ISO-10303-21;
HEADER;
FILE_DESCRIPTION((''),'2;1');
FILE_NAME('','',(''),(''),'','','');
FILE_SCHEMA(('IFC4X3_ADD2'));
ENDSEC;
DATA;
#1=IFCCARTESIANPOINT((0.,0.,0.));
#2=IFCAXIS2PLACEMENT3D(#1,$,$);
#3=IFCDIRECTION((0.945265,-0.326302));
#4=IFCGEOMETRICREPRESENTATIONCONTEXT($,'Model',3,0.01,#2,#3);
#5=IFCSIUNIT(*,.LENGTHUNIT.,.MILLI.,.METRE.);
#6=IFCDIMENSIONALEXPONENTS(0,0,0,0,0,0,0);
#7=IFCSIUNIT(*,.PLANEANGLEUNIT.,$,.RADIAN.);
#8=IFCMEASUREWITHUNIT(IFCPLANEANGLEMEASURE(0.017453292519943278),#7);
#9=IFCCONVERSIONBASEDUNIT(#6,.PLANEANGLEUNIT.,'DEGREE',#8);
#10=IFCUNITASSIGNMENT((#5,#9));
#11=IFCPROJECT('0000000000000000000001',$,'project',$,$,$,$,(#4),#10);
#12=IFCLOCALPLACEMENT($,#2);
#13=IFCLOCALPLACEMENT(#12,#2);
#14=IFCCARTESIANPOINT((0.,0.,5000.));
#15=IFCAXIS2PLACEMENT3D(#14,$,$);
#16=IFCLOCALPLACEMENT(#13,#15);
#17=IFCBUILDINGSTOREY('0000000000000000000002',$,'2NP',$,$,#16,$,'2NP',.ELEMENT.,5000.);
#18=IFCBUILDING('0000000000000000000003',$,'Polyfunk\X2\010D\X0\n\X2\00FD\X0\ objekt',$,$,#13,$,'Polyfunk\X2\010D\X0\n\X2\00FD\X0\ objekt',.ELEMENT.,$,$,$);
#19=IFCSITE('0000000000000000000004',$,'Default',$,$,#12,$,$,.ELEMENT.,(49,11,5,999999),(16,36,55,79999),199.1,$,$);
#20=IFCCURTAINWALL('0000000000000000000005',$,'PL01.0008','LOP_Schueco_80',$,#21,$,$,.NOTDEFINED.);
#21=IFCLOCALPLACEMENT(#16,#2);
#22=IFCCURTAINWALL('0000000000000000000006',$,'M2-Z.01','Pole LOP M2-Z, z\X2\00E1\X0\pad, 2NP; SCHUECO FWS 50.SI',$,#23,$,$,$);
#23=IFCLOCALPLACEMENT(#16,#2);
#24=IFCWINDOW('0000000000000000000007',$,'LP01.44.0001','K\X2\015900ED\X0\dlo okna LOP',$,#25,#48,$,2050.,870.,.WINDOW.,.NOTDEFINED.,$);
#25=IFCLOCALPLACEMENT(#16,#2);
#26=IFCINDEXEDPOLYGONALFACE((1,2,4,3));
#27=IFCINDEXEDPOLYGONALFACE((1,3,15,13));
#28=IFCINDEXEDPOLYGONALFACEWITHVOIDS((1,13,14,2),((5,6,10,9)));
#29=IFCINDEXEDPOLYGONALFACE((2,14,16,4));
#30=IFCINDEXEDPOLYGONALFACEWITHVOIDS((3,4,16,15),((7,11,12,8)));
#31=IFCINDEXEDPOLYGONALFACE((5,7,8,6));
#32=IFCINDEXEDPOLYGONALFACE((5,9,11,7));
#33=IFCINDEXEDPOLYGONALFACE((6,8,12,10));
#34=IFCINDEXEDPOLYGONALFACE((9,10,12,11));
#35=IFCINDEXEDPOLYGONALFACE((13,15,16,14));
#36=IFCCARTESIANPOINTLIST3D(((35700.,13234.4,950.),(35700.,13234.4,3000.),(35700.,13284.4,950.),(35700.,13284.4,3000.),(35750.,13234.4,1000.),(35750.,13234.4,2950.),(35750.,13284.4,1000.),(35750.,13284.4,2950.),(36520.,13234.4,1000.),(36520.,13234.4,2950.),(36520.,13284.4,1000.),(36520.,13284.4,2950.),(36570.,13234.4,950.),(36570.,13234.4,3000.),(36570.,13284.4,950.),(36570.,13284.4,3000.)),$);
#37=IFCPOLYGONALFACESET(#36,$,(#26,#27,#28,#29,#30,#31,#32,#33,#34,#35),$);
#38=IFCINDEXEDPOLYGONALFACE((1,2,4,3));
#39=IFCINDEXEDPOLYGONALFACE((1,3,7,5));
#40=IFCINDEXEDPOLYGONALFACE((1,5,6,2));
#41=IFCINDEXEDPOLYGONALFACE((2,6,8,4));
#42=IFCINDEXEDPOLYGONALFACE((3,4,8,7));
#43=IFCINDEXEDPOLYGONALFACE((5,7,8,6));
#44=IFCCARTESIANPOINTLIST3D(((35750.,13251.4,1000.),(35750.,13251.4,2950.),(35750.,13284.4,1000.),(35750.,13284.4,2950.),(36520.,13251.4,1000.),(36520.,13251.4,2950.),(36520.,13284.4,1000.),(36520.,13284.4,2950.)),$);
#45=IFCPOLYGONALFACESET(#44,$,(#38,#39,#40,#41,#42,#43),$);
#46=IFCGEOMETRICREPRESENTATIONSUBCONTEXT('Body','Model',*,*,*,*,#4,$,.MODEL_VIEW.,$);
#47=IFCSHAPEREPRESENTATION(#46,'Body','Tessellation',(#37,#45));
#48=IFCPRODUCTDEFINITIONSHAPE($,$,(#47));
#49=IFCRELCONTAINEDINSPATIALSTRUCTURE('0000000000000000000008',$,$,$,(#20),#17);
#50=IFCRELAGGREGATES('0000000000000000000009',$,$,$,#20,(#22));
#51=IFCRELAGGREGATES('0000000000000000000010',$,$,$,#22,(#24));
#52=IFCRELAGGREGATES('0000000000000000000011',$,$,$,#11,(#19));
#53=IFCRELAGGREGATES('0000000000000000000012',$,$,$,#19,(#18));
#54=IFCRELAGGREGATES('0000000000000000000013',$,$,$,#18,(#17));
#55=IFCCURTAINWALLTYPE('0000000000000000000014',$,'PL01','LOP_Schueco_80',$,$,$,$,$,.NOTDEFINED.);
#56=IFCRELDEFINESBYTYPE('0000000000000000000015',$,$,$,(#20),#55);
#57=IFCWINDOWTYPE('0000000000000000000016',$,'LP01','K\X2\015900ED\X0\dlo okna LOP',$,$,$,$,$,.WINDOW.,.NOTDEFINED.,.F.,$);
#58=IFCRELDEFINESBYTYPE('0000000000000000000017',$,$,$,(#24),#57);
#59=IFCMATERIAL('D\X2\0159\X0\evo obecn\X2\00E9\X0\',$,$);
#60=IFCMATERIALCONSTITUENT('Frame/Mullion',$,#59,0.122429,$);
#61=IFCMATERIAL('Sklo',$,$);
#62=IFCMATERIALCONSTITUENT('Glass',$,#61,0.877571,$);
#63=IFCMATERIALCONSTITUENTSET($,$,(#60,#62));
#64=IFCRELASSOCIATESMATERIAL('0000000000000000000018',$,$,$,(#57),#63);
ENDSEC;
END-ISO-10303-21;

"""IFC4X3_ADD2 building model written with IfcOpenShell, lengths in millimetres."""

from ifc_helpers import new_model, entity, si_unit, converted_unit, direction, frame, origin, origin_2d_with_axis, place, context, subcontext, project, spatial, polyline, rectangle, outline, extrude, source, transform, mapped, material, constituent, constituent_set, type_object, type_shapes, element, aggregate, save


model = new_model("IFC4X3_ADD2")

# Units and contexts
model_context = context("Model", 3, precision=0.01, world=origin(), true_north=direction((0.945265, -0.326302)))
body_context = subcontext(model_context, "Body", "Model", "MODEL_VIEW")
ifc_project = project(units=[si_unit("LENGTHUNIT", "METRE", prefix="MILLI"), converted_unit("PLANEANGLEUNIT", "DEGREE", entity("IfcPlaneAngleMeasure", 0.017453292519943278), si_unit("PLANEANGLEUNIT", "RADIAN"), dimensions=[0, 0, 0, 0, 0, 0, 0])], contexts=[model_context])

# Site, building, storey
site_placement = place(None, origin())
site = spatial("IfcSite", under=ifc_project, at=site_placement, Name="Default", CompositionType="ELEMENT", RefLatitude=(49, 11, 5, 999999), RefLongitude=(16, 36, 55, 79999), RefElevation=199.1)
building_placement = place(site_placement, origin())
building = spatial("IfcBuilding", under=site, at=building_placement, Name="Polyfunkčný objekt", LongName="Polyfunkčný objekt", CompositionType="ELEMENT")
storey_placement = place(building_placement, frame((0.0, 0.0, 5000.0)))
storey = spatial("IfcBuildingStorey", under=building, at=storey_placement, Name="2NP", LongName="2NP", CompositionType="ELEMENT", Elevation=5000.0)

# Curtain walls
curtain_wall_type = type_object("IfcCurtainWallType", Name="PL01", Description="LOP_Schueco_80", PredefinedType="NOTDEFINED")
curtain_wall_1_placement = place(storey_placement, frame((0.0, 0.0, -5000.0)))
curtain_wall_1 = element("IfcCurtainWall", 1, at=curtain_wall_1_placement, inside=storey, type_object=curtain_wall_type, Name="PL01.0008", Description="LOP_Schueco_80", PredefinedType="NOTDEFINED")
curtain_wall_2 = element("IfcCurtainWall", 2, Name="M2-Z.01", Description="Pole LOP M2-Z, západ, 2NP; SCHUECO FWS 50.SI")
aggregate(curtain_wall_1, [curtain_wall_2])
ifc_material_1 = material(Name="Sklo")

# Window
ifc_material_2 = material(Name="Dřevo obecné")
ifc_constituent_1 = constituent(ifc_material_2, Name="Frame/Mullion", fraction=0.122429)
ifc_constituent_2 = constituent(ifc_material_1, Name="Glass", fraction=0.877571)
ifc_constituent_set = constituent_set(constituents=[ifc_constituent_1, ifc_constituent_2])
window_type = type_object("IfcWindowType", Name="LP01", Description="Křídlo okna LOP", ParameterTakesPrecedence=False, PartitioningType="NOTDEFINED", PredefinedType="WINDOW", material=ifc_constituent_set)
shared_shape_1 = source(origin(), body_context, "Body", "SweptSolid", [
    extrude(outline(polyline([(-1025.0, -435.0), (1025.0, -435.0), (1025.0, 435.0), (-1025.0, 435.0), (-1025.0, -435.0)]), holes=[polyline([(-975.0, -385.0), (-975.0, 385.0), (975.0, 385.0), (975.0, -385.0), (-975.0, -385.0)])]), frame((0.0, 0.0, 1025.0), z_axis=(0.0, 1.0, 0.0), x_axis=(0.0, 0.0, -1.0)), (0.0, 0.0, 1.0), 50.0),
    extrude(rectangle(XDim=33.0, YDim=770.0, at=origin_2d_with_axis()), frame((0.0, 33.5, 50.0), z_axis=(0.0, 0.0, 1.0), x_axis=(0.0, -1.0, 0.0)), (0.0, 0.0, 1.0), 1950.0),
])
type_shapes(window_type, [shared_shape_1])
window_placement = place(curtain_wall_1_placement, frame((36135.0, 13234.4, 5950.0)))
window = element("IfcWindow", 3, at=window_placement, type_object=window_type, Name="LP01.44.0001", Description="Křídlo okna LOP", OverallHeight=2050.0, OverallWidth=870.0, PartitioningType="NOTDEFINED", PredefinedType="WINDOW", context=body_context, shape_type="MappedRepresentation", body=[
    mapped(shared_shape_1, transform((0.0, 0.0, 0.0), scale=1.0)),
])
aggregate(curtain_wall_2, [window])

save(model, "model.ifc")
